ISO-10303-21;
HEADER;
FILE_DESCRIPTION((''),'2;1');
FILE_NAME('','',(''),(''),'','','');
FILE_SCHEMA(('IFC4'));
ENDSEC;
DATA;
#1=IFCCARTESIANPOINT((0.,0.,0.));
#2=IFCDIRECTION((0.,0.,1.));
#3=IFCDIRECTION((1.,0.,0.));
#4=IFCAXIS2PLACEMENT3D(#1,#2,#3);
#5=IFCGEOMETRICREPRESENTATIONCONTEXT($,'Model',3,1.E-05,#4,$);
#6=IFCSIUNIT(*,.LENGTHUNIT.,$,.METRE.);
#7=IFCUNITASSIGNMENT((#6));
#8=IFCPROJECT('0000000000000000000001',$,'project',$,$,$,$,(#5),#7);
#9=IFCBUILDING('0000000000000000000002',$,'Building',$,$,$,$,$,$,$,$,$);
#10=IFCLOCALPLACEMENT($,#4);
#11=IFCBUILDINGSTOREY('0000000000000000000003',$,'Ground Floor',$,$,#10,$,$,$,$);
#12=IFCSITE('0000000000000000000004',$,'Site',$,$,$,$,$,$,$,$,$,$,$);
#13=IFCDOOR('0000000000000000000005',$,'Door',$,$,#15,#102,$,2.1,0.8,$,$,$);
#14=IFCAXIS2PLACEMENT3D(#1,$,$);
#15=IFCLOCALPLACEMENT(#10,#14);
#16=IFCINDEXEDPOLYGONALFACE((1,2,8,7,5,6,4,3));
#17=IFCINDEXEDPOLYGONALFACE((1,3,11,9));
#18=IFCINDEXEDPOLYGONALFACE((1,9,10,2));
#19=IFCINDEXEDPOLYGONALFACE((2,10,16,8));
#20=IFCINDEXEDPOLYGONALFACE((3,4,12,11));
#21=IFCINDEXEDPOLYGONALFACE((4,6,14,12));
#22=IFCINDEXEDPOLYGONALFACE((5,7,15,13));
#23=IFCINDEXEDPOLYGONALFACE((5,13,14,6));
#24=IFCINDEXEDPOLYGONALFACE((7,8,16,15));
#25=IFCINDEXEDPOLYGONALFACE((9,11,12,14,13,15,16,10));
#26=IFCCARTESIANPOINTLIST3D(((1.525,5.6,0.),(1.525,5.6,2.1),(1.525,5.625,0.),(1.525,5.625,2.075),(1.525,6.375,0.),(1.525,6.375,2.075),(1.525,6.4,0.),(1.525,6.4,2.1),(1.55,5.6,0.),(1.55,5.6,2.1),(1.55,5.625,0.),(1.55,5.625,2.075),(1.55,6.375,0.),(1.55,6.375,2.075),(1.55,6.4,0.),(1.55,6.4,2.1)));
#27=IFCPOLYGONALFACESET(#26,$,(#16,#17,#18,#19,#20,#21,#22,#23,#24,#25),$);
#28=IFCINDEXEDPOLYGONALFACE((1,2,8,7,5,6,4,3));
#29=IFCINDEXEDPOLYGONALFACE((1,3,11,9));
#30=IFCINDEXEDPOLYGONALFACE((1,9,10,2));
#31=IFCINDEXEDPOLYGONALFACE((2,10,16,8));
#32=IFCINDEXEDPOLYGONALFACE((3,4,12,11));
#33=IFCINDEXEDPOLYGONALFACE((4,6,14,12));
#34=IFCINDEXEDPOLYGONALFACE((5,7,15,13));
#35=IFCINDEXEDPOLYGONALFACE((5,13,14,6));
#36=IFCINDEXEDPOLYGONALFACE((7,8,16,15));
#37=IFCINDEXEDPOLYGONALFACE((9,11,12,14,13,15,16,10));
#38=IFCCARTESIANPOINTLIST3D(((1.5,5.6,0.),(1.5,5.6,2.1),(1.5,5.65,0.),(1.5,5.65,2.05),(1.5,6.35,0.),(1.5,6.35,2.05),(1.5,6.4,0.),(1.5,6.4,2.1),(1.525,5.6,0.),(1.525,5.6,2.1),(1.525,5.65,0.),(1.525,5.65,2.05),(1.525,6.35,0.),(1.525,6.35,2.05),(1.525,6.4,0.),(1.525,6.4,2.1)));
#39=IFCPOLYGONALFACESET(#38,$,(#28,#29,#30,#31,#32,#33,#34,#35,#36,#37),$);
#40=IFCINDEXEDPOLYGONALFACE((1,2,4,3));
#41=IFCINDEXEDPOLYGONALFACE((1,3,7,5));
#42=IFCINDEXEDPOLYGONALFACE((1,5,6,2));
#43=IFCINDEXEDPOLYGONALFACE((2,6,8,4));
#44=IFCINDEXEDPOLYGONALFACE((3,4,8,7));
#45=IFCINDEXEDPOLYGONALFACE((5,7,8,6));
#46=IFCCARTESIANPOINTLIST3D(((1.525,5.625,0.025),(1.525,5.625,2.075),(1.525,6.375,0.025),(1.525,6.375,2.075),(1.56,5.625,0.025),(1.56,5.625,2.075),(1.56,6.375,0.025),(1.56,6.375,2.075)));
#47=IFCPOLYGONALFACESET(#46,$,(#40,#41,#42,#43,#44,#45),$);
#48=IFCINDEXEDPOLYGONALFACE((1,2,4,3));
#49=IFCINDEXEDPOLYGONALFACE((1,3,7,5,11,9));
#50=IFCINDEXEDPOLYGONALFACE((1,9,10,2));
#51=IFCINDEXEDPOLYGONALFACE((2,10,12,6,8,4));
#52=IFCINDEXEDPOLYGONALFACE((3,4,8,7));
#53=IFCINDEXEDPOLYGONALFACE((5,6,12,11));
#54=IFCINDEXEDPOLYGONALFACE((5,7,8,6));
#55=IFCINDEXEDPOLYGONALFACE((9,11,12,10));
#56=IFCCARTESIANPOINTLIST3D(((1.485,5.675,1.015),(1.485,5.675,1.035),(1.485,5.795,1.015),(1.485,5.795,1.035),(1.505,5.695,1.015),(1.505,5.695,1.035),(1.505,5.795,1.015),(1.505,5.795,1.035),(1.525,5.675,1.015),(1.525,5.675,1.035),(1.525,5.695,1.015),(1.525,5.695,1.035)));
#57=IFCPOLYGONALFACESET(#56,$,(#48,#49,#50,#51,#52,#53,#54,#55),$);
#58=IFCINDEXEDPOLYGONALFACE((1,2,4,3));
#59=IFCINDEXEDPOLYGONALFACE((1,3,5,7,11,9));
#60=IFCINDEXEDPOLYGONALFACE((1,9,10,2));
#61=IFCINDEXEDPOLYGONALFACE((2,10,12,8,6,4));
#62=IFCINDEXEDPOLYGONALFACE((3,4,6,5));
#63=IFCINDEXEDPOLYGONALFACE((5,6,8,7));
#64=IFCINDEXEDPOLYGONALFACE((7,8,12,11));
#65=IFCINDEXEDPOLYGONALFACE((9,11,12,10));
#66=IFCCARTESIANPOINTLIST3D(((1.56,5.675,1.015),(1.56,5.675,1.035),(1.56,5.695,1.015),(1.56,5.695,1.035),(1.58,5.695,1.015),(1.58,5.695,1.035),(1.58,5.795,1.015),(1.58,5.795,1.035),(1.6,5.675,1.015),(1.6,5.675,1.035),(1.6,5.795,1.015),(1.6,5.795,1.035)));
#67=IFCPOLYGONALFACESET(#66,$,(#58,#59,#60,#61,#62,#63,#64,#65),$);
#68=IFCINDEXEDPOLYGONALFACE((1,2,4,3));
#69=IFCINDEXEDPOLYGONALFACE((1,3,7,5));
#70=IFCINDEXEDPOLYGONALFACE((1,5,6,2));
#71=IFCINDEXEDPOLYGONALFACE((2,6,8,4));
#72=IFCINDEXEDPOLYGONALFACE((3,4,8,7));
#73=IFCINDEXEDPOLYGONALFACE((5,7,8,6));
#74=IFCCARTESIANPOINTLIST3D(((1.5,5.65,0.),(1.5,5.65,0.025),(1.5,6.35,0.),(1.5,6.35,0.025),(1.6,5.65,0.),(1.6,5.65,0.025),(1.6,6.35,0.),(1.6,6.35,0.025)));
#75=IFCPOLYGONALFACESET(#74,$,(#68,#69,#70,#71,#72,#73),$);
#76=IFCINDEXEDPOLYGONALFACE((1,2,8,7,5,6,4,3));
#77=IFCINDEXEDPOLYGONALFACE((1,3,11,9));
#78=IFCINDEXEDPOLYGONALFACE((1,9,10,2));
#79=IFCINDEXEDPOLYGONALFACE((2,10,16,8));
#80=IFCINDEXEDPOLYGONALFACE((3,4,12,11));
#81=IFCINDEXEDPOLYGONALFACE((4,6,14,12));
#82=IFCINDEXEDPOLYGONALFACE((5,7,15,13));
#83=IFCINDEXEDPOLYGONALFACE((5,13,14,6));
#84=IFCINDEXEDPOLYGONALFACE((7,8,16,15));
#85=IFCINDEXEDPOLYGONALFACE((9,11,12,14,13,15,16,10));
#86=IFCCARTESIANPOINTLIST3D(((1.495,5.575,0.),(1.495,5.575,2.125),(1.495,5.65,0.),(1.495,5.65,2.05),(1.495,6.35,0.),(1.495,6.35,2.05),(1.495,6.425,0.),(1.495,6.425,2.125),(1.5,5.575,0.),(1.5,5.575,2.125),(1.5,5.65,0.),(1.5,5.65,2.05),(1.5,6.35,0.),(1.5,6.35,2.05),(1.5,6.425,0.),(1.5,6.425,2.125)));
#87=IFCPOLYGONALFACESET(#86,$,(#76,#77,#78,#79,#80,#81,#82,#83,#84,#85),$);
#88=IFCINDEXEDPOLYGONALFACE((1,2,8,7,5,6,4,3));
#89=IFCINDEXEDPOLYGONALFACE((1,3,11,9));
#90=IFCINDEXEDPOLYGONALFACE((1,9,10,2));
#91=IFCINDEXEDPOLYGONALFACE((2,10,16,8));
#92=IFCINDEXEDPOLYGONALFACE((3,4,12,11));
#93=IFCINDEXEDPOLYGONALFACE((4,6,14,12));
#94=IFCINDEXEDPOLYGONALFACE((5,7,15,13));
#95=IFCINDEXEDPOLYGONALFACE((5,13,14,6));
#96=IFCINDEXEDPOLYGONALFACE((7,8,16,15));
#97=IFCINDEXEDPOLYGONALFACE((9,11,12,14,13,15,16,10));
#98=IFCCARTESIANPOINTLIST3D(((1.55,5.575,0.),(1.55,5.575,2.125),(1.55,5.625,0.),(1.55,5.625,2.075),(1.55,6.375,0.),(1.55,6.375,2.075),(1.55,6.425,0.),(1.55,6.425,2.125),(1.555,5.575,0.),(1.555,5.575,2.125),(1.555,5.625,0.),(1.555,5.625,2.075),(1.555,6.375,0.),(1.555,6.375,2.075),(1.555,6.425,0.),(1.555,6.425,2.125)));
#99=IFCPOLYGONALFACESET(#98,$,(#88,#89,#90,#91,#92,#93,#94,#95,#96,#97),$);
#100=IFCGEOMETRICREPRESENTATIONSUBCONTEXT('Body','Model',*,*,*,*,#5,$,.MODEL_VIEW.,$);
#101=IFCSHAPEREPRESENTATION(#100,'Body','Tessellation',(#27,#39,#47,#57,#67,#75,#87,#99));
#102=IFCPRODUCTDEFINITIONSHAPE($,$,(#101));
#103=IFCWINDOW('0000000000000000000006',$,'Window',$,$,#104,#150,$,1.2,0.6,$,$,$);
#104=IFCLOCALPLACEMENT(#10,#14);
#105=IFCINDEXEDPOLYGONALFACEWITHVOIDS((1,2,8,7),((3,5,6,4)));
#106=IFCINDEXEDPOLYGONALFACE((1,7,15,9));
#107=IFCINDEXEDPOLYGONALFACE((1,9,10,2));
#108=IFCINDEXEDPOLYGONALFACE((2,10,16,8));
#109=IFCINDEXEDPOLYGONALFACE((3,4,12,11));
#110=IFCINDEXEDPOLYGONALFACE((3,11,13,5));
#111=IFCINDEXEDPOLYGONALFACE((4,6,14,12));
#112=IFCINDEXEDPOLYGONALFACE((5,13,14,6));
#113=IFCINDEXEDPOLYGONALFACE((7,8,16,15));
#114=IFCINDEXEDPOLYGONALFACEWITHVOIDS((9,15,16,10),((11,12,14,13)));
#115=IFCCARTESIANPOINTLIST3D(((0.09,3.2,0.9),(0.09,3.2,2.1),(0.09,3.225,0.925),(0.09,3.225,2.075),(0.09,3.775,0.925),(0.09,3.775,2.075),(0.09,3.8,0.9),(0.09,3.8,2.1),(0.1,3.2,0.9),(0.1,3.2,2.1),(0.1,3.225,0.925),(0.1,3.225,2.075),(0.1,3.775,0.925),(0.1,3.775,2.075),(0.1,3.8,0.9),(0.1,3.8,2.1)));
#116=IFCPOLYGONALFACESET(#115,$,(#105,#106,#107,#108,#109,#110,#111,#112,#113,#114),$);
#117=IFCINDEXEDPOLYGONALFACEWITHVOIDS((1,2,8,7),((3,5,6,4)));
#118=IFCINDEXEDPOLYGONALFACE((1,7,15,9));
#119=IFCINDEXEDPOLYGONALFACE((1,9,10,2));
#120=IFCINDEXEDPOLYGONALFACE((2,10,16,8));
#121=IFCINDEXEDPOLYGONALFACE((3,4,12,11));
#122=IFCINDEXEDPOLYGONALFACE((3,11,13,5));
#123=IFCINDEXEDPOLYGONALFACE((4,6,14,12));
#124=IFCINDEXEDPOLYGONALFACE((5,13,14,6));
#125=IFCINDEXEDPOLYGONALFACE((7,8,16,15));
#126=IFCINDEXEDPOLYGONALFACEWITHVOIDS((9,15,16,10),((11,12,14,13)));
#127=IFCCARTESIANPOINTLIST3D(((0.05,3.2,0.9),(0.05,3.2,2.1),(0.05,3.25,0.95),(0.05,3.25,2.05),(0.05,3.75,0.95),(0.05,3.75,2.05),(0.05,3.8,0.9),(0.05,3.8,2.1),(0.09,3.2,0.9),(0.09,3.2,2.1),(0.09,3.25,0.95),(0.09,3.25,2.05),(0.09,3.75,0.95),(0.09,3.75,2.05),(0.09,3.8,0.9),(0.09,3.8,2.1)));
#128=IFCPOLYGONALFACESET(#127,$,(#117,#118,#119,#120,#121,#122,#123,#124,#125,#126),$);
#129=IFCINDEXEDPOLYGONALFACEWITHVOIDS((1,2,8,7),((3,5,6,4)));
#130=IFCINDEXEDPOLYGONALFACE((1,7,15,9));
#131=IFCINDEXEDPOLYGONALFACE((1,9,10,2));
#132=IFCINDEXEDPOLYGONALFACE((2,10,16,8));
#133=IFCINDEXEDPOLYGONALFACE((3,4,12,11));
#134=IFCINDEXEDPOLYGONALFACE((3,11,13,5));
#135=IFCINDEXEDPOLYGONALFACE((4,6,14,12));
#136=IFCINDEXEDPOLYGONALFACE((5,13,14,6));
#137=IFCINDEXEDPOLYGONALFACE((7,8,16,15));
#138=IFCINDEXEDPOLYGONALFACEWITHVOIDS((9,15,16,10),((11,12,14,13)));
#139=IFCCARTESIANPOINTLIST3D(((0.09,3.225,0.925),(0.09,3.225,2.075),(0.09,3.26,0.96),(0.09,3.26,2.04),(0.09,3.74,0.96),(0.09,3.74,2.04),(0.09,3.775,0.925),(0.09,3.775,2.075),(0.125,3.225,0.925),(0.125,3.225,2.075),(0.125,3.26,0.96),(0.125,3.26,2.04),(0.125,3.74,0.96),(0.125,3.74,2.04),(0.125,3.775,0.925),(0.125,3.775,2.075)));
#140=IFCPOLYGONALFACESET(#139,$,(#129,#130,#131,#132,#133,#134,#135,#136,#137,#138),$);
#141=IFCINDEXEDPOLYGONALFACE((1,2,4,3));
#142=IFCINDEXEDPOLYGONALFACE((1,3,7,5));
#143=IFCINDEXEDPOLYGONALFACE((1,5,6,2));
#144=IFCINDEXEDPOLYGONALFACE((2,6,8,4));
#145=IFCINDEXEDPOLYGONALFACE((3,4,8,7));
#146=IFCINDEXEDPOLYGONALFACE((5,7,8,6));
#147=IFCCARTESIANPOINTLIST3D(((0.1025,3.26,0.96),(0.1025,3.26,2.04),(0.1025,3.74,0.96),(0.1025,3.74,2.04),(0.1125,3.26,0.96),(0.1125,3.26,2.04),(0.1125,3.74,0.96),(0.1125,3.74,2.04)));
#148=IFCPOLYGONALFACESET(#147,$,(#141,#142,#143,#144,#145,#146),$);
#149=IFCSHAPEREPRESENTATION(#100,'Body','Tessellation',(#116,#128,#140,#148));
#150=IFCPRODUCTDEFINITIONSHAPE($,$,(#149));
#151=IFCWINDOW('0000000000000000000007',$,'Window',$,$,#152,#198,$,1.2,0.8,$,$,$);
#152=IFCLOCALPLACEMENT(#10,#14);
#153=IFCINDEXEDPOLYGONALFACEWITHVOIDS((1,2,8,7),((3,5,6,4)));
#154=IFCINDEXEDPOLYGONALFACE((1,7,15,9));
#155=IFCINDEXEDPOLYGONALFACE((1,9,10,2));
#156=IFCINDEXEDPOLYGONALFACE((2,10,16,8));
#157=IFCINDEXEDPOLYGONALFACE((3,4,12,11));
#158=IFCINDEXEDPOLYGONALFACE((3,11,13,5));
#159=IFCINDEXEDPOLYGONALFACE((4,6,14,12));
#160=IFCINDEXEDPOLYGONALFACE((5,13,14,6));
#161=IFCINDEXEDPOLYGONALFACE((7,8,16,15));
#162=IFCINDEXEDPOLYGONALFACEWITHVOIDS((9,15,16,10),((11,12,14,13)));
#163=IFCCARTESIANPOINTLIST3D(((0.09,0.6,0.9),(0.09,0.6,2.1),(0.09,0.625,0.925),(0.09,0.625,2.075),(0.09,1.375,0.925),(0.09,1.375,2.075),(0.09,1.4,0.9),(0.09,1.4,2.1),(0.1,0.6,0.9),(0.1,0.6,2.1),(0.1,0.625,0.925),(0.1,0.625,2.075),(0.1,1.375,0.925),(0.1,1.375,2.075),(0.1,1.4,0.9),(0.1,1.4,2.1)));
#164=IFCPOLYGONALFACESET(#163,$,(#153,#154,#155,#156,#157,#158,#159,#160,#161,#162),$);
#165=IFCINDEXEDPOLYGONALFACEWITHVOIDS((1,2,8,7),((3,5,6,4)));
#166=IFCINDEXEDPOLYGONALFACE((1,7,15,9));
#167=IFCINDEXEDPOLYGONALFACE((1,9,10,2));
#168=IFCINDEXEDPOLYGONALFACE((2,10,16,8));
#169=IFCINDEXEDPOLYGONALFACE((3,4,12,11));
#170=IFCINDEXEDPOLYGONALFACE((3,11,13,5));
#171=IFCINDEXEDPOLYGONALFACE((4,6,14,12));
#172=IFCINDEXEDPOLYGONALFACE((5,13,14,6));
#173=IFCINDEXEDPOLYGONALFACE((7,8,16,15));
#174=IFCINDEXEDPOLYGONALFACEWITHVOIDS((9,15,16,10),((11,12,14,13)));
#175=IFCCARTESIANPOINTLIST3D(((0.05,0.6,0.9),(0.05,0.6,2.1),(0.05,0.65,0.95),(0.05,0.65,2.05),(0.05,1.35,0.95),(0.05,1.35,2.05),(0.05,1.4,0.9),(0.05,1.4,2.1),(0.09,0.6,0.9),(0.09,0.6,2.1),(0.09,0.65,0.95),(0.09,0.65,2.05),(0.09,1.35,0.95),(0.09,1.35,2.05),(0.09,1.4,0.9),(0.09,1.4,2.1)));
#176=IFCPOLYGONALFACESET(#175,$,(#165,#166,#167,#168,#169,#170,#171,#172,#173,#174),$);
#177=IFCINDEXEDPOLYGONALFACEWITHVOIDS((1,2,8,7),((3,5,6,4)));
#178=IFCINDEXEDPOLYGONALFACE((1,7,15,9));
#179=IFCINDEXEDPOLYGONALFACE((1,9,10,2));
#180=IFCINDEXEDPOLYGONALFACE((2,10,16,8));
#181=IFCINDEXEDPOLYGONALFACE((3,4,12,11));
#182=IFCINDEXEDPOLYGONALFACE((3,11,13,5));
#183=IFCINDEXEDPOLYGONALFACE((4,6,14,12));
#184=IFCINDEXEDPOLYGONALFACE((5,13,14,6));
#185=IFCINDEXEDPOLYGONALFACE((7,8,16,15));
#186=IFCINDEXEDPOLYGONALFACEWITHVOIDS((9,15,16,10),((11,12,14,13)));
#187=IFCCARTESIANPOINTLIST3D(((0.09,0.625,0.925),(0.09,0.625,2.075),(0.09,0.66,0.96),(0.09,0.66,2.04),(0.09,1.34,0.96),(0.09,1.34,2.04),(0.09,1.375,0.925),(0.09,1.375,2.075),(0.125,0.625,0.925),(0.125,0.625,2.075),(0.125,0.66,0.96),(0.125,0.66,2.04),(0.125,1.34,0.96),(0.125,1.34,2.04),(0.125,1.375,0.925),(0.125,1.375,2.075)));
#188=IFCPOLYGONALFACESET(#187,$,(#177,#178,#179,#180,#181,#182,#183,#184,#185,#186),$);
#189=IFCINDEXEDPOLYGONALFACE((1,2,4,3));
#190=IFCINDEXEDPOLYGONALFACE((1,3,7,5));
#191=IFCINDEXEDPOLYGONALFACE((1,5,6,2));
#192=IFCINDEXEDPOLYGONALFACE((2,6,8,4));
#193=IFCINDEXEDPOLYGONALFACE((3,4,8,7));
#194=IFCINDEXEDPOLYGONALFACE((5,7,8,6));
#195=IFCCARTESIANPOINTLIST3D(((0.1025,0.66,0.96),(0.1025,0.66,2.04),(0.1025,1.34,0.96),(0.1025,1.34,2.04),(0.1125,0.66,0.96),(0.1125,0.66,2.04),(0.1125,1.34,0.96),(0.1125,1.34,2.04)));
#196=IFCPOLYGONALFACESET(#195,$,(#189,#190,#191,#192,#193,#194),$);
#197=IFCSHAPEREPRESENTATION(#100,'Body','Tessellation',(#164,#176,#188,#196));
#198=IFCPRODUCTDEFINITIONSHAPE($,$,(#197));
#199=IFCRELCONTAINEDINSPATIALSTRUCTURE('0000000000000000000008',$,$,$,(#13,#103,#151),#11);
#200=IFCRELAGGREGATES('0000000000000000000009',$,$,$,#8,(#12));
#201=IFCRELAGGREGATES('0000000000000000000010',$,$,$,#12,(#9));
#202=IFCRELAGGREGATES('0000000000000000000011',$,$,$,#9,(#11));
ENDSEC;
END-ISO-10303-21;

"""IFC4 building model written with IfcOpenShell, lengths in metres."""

from ifc_helpers import new_model, si_unit, frame, origin_with_axes, place, context, subcontext, project, spatial, line, indexed_curve, outline, extrude, element, save


model = new_model("IFC4")

# Units and contexts
model_context = context("Model", 3, precision=1e-05, world=origin_with_axes())
body_context = subcontext(model_context, "Body", "Model", "MODEL_VIEW")
ifc_project = project(units=[si_unit("LENGTHUNIT", "METRE")], contexts=[model_context])

# Site, building, storey
site = spatial("IfcSite", under=ifc_project, Name="Site")
building = spatial("IfcBuilding", under=site, Name="Building")
storey_placement = place(None, origin_with_axes())
storey = spatial("IfcBuildingStorey", under=building, at=storey_placement, Name="Ground Floor")

# Door
door_1_placement = place(storey_placement, frame((1.5, 6.4, 0.0), z_axis=(0.0, 0.0, 1.0), x_axis=(0.0, -1.0, 0.0)))
element("IfcDoor", 1, at=door_1_placement, inside=storey, Name="Door", OverallHeight=2.1, OverallWidth=0.8, context=body_context, shape_type="SweptSolid", body=[
    extrude(outline(indexed_curve([(0.0, 0.0), (0.0, 2.1), (0.8, 2.1), (0.8, 0.0), (0.775, 0.0), (0.775, 2.075), (0.025, 2.075), (0.025, 0.0)], segments=[line(1, 2, 3, 4, 5, 6, 7, 8, 1)])), frame((0.0, 0.025, 0.0), z_axis=(0.0, -1.0, 0.0), x_axis=(1.0, 0.0, 0.0)), (0.0, 0.0, -1.0), 0.025),
    extrude(outline(indexed_curve([(0.0, 0.0), (0.0, 2.1), (0.8, 2.1), (0.8, 0.0), (0.75, 0.0), (0.75, 2.05), (0.05, 2.05), (0.05, 0.0)], segments=[line(1, 2, 3, 4, 5, 6, 7, 8, 1)])), frame((0.0, 0.0, 0.0), z_axis=(0.0, -1.0, 0.0), x_axis=(1.0, 0.0, 0.0)), (0.0, 0.0, -1.0), 0.025),
    extrude(outline(indexed_curve([(0.0, 0.0), (0.75, 0.0), (0.75, 0.035), (0.0, 0.035)], segments=[line(1, 2, 3, 4, 1)])), frame((0.025, 0.025, 0.025), z_axis=(0.0, 0.0, 1.0), x_axis=(1.0, 0.0, 0.0)), (0.0, 0.0, 1.0), 2.05),
    extrude(outline(indexed_curve([(0.0, 0.0), (0.0, -0.04), (-0.12, -0.04), (-0.12, -0.02), (-0.02, -0.02), (-0.02, 0.0)], segments=[line(1, 2, 3, 4, 5, 6, 1)])), frame((0.725, 0.025, 1.015), z_axis=(0.0, 0.0, 1.0), x_axis=(1.0, 0.0, 0.0)), (0.0, 0.0, 1.0), 0.02),
    extrude(outline(indexed_curve([(0.0, 0.0), (0.0, 0.04), (-0.12, 0.04), (-0.12, 0.02), (-0.02, 0.02), (-0.02, 0.0)], segments=[line(1, 2, 3, 4, 5, 6, 1)])), frame((0.725, 0.06, 1.015), z_axis=(0.0, 0.0, 1.0), x_axis=(1.0, 0.0, 0.0)), (0.0, 0.0, 1.0), 0.02),
    extrude(outline(indexed_curve([(0.0, 0.0), (0.7, 0.0), (0.7, 0.1), (0.0, 0.1)], segments=[line(1, 2, 3, 4, 1)])), frame((0.05, 0.0, 0.0), z_axis=(0.0, 0.0, 1.0), x_axis=(1.0, 0.0, 0.0)), (0.0, 0.0, 1.0), 0.025),
    extrude(outline(indexed_curve([(0.0, 0.0), (0.0, 2.125), (0.85, 2.125), (0.85, 0.0), (0.775, 0.0), (0.775, 2.05), (0.075, 2.05), (0.075, 0.0)], segments=[line(1, 2, 3, 4, 5, 6, 7, 8, 1)])), frame((-0.025, -0.005, 0.0), z_axis=(0.0, -1.0, 0.0), x_axis=(1.0, 0.0, 0.0)), (0.0, 0.0, -1.0), 0.005),
    extrude(outline(indexed_curve([(0.0, 0.0), (0.0, 2.125), (0.85, 2.125), (0.85, 0.0), (0.8, 0.0), (0.8, 2.075), (0.05, 2.075), (0.05, 0.0)], segments=[line(1, 2, 3, 4, 5, 6, 7, 8, 1)])), frame((-0.025, 0.05, 0.0), z_axis=(0.0, -1.0, 0.0), x_axis=(1.0, 0.0, 0.0)), (0.0, 0.0, -1.0), 0.005),
])

# Windows
window_1_placement = place(storey_placement, frame((0.0, 3.8, 0.9), z_axis=(0.0, 0.0, 1.0), x_axis=(0.0, -1.0, 0.0)))
element("IfcWindow", 2, at=window_1_placement, inside=storey, Name="Window", OverallHeight=1.2, OverallWidth=0.6, context=body_context, shape_type="SweptSolid", body=[
    extrude(outline(indexed_curve([(0.0, 0.0), (0.6, 0.0), (0.6, 1.2), (0.0, 1.2)], segments=[line(1, 2, 3, 4, 1)]), holes=[indexed_curve([(0.025, 0.025), (0.575, 0.025), (0.575, 1.175), (0.025, 1.175)], segments=[line(1, 2, 3, 4, 1)])]), frame((0.0, 0.09, 0.0), z_axis=(0.0, -1.0, 0.0), x_axis=(1.0, 0.0, 0.0)), (0.0, 0.0, -1.0), 0.01),
    extrude(outline(indexed_curve([(0.0, 0.0), (0.6, 0.0), (0.6, 1.2), (0.0, 1.2)], segments=[line(1, 2, 3, 4, 1)]), holes=[indexed_curve([(0.05, 0.05), (0.55, 0.05), (0.55, 1.15), (0.05, 1.15)], segments=[line(1, 2, 3, 4, 1)])]), frame((0.0, 0.05, 0.0), z_axis=(0.0, -1.0, 0.0), x_axis=(1.0, 0.0, 0.0)), (0.0, 0.0, -1.0), 0.04),
    extrude(outline(indexed_curve([(0.0, 0.0), (0.55, 0.0), (0.55, 1.15), (0.0, 1.15)], segments=[line(1, 2, 3, 4, 1)]), holes=[indexed_curve([(0.035, 0.035), (0.515, 0.035), (0.515, 1.115), (0.035, 1.115)], segments=[line(1, 2, 3, 4, 1)])]), frame((0.025, 0.09, 0.025), z_axis=(0.0, -1.0, 0.0), x_axis=(1.0, 0.0, 0.0)), (0.0, 0.0, -1.0), 0.035),
    extrude(outline(indexed_curve([(0.035, 0.035), (0.515, 0.035), (0.515, 1.115), (0.035, 1.115)], segments=[line(1, 2, 3, 4, 1)])), frame((0.025, 0.1025, 0.025), z_axis=(0.0, -1.0, 0.0), x_axis=(1.0, 0.0, 0.0)), (0.0, 0.0, -1.0), 0.01),
])
window_2_placement = place(storey_placement, frame((0.0, 1.4, 0.9), z_axis=(0.0, 0.0, 1.0), x_axis=(0.0, -1.0, 0.0)))
element("IfcWindow", 3, at=window_2_placement, inside=storey, Name="Window", OverallHeight=1.2, OverallWidth=0.8, context=body_context, shape_type="SweptSolid", body=[
    extrude(outline(indexed_curve([(0.0, 0.0), (0.8, 0.0), (0.8, 1.2), (0.0, 1.2)], segments=[line(1, 2, 3, 4, 1)]), holes=[indexed_curve([(0.025, 0.025), (0.775, 0.025), (0.775, 1.175), (0.025, 1.175)], segments=[line(1, 2, 3, 4, 1)])]), frame((0.0, 0.09, 0.0), z_axis=(0.0, -1.0, 0.0), x_axis=(1.0, 0.0, 0.0)), (0.0, 0.0, -1.0), 0.01),
    extrude(outline(indexed_curve([(0.0, 0.0), (0.8, 0.0), (0.8, 1.2), (0.0, 1.2)], segments=[line(1, 2, 3, 4, 1)]), holes=[indexed_curve([(0.05, 0.05), (0.75, 0.05), (0.75, 1.15), (0.05, 1.15)], segments=[line(1, 2, 3, 4, 1)])]), frame((0.0, 0.05, 0.0), z_axis=(0.0, -1.0, 0.0), x_axis=(1.0, 0.0, 0.0)), (0.0, 0.0, -1.0), 0.04),
    extrude(outline(indexed_curve([(0.0, 0.0), (0.75, 0.0), (0.75, 1.15), (0.0, 1.15)], segments=[line(1, 2, 3, 4, 1)]), holes=[indexed_curve([(0.035, 0.035), (0.715, 0.035), (0.715, 1.115), (0.035, 1.115)], segments=[line(1, 2, 3, 4, 1)])]), frame((0.025, 0.09, 0.025), z_axis=(0.0, -1.0, 0.0), x_axis=(1.0, 0.0, 0.0)), (0.0, 0.0, -1.0), 0.035),
    extrude(outline(indexed_curve([(0.035, 0.035), (0.715, 0.035), (0.715, 1.115), (0.035, 1.115)], segments=[line(1, 2, 3, 4, 1)])), frame((0.025, 0.1025, 0.025), z_axis=(0.0, -1.0, 0.0), x_axis=(1.0, 0.0, 0.0)), (0.0, 0.0, -1.0), 0.01),
])

save(model, "model.ifc")
